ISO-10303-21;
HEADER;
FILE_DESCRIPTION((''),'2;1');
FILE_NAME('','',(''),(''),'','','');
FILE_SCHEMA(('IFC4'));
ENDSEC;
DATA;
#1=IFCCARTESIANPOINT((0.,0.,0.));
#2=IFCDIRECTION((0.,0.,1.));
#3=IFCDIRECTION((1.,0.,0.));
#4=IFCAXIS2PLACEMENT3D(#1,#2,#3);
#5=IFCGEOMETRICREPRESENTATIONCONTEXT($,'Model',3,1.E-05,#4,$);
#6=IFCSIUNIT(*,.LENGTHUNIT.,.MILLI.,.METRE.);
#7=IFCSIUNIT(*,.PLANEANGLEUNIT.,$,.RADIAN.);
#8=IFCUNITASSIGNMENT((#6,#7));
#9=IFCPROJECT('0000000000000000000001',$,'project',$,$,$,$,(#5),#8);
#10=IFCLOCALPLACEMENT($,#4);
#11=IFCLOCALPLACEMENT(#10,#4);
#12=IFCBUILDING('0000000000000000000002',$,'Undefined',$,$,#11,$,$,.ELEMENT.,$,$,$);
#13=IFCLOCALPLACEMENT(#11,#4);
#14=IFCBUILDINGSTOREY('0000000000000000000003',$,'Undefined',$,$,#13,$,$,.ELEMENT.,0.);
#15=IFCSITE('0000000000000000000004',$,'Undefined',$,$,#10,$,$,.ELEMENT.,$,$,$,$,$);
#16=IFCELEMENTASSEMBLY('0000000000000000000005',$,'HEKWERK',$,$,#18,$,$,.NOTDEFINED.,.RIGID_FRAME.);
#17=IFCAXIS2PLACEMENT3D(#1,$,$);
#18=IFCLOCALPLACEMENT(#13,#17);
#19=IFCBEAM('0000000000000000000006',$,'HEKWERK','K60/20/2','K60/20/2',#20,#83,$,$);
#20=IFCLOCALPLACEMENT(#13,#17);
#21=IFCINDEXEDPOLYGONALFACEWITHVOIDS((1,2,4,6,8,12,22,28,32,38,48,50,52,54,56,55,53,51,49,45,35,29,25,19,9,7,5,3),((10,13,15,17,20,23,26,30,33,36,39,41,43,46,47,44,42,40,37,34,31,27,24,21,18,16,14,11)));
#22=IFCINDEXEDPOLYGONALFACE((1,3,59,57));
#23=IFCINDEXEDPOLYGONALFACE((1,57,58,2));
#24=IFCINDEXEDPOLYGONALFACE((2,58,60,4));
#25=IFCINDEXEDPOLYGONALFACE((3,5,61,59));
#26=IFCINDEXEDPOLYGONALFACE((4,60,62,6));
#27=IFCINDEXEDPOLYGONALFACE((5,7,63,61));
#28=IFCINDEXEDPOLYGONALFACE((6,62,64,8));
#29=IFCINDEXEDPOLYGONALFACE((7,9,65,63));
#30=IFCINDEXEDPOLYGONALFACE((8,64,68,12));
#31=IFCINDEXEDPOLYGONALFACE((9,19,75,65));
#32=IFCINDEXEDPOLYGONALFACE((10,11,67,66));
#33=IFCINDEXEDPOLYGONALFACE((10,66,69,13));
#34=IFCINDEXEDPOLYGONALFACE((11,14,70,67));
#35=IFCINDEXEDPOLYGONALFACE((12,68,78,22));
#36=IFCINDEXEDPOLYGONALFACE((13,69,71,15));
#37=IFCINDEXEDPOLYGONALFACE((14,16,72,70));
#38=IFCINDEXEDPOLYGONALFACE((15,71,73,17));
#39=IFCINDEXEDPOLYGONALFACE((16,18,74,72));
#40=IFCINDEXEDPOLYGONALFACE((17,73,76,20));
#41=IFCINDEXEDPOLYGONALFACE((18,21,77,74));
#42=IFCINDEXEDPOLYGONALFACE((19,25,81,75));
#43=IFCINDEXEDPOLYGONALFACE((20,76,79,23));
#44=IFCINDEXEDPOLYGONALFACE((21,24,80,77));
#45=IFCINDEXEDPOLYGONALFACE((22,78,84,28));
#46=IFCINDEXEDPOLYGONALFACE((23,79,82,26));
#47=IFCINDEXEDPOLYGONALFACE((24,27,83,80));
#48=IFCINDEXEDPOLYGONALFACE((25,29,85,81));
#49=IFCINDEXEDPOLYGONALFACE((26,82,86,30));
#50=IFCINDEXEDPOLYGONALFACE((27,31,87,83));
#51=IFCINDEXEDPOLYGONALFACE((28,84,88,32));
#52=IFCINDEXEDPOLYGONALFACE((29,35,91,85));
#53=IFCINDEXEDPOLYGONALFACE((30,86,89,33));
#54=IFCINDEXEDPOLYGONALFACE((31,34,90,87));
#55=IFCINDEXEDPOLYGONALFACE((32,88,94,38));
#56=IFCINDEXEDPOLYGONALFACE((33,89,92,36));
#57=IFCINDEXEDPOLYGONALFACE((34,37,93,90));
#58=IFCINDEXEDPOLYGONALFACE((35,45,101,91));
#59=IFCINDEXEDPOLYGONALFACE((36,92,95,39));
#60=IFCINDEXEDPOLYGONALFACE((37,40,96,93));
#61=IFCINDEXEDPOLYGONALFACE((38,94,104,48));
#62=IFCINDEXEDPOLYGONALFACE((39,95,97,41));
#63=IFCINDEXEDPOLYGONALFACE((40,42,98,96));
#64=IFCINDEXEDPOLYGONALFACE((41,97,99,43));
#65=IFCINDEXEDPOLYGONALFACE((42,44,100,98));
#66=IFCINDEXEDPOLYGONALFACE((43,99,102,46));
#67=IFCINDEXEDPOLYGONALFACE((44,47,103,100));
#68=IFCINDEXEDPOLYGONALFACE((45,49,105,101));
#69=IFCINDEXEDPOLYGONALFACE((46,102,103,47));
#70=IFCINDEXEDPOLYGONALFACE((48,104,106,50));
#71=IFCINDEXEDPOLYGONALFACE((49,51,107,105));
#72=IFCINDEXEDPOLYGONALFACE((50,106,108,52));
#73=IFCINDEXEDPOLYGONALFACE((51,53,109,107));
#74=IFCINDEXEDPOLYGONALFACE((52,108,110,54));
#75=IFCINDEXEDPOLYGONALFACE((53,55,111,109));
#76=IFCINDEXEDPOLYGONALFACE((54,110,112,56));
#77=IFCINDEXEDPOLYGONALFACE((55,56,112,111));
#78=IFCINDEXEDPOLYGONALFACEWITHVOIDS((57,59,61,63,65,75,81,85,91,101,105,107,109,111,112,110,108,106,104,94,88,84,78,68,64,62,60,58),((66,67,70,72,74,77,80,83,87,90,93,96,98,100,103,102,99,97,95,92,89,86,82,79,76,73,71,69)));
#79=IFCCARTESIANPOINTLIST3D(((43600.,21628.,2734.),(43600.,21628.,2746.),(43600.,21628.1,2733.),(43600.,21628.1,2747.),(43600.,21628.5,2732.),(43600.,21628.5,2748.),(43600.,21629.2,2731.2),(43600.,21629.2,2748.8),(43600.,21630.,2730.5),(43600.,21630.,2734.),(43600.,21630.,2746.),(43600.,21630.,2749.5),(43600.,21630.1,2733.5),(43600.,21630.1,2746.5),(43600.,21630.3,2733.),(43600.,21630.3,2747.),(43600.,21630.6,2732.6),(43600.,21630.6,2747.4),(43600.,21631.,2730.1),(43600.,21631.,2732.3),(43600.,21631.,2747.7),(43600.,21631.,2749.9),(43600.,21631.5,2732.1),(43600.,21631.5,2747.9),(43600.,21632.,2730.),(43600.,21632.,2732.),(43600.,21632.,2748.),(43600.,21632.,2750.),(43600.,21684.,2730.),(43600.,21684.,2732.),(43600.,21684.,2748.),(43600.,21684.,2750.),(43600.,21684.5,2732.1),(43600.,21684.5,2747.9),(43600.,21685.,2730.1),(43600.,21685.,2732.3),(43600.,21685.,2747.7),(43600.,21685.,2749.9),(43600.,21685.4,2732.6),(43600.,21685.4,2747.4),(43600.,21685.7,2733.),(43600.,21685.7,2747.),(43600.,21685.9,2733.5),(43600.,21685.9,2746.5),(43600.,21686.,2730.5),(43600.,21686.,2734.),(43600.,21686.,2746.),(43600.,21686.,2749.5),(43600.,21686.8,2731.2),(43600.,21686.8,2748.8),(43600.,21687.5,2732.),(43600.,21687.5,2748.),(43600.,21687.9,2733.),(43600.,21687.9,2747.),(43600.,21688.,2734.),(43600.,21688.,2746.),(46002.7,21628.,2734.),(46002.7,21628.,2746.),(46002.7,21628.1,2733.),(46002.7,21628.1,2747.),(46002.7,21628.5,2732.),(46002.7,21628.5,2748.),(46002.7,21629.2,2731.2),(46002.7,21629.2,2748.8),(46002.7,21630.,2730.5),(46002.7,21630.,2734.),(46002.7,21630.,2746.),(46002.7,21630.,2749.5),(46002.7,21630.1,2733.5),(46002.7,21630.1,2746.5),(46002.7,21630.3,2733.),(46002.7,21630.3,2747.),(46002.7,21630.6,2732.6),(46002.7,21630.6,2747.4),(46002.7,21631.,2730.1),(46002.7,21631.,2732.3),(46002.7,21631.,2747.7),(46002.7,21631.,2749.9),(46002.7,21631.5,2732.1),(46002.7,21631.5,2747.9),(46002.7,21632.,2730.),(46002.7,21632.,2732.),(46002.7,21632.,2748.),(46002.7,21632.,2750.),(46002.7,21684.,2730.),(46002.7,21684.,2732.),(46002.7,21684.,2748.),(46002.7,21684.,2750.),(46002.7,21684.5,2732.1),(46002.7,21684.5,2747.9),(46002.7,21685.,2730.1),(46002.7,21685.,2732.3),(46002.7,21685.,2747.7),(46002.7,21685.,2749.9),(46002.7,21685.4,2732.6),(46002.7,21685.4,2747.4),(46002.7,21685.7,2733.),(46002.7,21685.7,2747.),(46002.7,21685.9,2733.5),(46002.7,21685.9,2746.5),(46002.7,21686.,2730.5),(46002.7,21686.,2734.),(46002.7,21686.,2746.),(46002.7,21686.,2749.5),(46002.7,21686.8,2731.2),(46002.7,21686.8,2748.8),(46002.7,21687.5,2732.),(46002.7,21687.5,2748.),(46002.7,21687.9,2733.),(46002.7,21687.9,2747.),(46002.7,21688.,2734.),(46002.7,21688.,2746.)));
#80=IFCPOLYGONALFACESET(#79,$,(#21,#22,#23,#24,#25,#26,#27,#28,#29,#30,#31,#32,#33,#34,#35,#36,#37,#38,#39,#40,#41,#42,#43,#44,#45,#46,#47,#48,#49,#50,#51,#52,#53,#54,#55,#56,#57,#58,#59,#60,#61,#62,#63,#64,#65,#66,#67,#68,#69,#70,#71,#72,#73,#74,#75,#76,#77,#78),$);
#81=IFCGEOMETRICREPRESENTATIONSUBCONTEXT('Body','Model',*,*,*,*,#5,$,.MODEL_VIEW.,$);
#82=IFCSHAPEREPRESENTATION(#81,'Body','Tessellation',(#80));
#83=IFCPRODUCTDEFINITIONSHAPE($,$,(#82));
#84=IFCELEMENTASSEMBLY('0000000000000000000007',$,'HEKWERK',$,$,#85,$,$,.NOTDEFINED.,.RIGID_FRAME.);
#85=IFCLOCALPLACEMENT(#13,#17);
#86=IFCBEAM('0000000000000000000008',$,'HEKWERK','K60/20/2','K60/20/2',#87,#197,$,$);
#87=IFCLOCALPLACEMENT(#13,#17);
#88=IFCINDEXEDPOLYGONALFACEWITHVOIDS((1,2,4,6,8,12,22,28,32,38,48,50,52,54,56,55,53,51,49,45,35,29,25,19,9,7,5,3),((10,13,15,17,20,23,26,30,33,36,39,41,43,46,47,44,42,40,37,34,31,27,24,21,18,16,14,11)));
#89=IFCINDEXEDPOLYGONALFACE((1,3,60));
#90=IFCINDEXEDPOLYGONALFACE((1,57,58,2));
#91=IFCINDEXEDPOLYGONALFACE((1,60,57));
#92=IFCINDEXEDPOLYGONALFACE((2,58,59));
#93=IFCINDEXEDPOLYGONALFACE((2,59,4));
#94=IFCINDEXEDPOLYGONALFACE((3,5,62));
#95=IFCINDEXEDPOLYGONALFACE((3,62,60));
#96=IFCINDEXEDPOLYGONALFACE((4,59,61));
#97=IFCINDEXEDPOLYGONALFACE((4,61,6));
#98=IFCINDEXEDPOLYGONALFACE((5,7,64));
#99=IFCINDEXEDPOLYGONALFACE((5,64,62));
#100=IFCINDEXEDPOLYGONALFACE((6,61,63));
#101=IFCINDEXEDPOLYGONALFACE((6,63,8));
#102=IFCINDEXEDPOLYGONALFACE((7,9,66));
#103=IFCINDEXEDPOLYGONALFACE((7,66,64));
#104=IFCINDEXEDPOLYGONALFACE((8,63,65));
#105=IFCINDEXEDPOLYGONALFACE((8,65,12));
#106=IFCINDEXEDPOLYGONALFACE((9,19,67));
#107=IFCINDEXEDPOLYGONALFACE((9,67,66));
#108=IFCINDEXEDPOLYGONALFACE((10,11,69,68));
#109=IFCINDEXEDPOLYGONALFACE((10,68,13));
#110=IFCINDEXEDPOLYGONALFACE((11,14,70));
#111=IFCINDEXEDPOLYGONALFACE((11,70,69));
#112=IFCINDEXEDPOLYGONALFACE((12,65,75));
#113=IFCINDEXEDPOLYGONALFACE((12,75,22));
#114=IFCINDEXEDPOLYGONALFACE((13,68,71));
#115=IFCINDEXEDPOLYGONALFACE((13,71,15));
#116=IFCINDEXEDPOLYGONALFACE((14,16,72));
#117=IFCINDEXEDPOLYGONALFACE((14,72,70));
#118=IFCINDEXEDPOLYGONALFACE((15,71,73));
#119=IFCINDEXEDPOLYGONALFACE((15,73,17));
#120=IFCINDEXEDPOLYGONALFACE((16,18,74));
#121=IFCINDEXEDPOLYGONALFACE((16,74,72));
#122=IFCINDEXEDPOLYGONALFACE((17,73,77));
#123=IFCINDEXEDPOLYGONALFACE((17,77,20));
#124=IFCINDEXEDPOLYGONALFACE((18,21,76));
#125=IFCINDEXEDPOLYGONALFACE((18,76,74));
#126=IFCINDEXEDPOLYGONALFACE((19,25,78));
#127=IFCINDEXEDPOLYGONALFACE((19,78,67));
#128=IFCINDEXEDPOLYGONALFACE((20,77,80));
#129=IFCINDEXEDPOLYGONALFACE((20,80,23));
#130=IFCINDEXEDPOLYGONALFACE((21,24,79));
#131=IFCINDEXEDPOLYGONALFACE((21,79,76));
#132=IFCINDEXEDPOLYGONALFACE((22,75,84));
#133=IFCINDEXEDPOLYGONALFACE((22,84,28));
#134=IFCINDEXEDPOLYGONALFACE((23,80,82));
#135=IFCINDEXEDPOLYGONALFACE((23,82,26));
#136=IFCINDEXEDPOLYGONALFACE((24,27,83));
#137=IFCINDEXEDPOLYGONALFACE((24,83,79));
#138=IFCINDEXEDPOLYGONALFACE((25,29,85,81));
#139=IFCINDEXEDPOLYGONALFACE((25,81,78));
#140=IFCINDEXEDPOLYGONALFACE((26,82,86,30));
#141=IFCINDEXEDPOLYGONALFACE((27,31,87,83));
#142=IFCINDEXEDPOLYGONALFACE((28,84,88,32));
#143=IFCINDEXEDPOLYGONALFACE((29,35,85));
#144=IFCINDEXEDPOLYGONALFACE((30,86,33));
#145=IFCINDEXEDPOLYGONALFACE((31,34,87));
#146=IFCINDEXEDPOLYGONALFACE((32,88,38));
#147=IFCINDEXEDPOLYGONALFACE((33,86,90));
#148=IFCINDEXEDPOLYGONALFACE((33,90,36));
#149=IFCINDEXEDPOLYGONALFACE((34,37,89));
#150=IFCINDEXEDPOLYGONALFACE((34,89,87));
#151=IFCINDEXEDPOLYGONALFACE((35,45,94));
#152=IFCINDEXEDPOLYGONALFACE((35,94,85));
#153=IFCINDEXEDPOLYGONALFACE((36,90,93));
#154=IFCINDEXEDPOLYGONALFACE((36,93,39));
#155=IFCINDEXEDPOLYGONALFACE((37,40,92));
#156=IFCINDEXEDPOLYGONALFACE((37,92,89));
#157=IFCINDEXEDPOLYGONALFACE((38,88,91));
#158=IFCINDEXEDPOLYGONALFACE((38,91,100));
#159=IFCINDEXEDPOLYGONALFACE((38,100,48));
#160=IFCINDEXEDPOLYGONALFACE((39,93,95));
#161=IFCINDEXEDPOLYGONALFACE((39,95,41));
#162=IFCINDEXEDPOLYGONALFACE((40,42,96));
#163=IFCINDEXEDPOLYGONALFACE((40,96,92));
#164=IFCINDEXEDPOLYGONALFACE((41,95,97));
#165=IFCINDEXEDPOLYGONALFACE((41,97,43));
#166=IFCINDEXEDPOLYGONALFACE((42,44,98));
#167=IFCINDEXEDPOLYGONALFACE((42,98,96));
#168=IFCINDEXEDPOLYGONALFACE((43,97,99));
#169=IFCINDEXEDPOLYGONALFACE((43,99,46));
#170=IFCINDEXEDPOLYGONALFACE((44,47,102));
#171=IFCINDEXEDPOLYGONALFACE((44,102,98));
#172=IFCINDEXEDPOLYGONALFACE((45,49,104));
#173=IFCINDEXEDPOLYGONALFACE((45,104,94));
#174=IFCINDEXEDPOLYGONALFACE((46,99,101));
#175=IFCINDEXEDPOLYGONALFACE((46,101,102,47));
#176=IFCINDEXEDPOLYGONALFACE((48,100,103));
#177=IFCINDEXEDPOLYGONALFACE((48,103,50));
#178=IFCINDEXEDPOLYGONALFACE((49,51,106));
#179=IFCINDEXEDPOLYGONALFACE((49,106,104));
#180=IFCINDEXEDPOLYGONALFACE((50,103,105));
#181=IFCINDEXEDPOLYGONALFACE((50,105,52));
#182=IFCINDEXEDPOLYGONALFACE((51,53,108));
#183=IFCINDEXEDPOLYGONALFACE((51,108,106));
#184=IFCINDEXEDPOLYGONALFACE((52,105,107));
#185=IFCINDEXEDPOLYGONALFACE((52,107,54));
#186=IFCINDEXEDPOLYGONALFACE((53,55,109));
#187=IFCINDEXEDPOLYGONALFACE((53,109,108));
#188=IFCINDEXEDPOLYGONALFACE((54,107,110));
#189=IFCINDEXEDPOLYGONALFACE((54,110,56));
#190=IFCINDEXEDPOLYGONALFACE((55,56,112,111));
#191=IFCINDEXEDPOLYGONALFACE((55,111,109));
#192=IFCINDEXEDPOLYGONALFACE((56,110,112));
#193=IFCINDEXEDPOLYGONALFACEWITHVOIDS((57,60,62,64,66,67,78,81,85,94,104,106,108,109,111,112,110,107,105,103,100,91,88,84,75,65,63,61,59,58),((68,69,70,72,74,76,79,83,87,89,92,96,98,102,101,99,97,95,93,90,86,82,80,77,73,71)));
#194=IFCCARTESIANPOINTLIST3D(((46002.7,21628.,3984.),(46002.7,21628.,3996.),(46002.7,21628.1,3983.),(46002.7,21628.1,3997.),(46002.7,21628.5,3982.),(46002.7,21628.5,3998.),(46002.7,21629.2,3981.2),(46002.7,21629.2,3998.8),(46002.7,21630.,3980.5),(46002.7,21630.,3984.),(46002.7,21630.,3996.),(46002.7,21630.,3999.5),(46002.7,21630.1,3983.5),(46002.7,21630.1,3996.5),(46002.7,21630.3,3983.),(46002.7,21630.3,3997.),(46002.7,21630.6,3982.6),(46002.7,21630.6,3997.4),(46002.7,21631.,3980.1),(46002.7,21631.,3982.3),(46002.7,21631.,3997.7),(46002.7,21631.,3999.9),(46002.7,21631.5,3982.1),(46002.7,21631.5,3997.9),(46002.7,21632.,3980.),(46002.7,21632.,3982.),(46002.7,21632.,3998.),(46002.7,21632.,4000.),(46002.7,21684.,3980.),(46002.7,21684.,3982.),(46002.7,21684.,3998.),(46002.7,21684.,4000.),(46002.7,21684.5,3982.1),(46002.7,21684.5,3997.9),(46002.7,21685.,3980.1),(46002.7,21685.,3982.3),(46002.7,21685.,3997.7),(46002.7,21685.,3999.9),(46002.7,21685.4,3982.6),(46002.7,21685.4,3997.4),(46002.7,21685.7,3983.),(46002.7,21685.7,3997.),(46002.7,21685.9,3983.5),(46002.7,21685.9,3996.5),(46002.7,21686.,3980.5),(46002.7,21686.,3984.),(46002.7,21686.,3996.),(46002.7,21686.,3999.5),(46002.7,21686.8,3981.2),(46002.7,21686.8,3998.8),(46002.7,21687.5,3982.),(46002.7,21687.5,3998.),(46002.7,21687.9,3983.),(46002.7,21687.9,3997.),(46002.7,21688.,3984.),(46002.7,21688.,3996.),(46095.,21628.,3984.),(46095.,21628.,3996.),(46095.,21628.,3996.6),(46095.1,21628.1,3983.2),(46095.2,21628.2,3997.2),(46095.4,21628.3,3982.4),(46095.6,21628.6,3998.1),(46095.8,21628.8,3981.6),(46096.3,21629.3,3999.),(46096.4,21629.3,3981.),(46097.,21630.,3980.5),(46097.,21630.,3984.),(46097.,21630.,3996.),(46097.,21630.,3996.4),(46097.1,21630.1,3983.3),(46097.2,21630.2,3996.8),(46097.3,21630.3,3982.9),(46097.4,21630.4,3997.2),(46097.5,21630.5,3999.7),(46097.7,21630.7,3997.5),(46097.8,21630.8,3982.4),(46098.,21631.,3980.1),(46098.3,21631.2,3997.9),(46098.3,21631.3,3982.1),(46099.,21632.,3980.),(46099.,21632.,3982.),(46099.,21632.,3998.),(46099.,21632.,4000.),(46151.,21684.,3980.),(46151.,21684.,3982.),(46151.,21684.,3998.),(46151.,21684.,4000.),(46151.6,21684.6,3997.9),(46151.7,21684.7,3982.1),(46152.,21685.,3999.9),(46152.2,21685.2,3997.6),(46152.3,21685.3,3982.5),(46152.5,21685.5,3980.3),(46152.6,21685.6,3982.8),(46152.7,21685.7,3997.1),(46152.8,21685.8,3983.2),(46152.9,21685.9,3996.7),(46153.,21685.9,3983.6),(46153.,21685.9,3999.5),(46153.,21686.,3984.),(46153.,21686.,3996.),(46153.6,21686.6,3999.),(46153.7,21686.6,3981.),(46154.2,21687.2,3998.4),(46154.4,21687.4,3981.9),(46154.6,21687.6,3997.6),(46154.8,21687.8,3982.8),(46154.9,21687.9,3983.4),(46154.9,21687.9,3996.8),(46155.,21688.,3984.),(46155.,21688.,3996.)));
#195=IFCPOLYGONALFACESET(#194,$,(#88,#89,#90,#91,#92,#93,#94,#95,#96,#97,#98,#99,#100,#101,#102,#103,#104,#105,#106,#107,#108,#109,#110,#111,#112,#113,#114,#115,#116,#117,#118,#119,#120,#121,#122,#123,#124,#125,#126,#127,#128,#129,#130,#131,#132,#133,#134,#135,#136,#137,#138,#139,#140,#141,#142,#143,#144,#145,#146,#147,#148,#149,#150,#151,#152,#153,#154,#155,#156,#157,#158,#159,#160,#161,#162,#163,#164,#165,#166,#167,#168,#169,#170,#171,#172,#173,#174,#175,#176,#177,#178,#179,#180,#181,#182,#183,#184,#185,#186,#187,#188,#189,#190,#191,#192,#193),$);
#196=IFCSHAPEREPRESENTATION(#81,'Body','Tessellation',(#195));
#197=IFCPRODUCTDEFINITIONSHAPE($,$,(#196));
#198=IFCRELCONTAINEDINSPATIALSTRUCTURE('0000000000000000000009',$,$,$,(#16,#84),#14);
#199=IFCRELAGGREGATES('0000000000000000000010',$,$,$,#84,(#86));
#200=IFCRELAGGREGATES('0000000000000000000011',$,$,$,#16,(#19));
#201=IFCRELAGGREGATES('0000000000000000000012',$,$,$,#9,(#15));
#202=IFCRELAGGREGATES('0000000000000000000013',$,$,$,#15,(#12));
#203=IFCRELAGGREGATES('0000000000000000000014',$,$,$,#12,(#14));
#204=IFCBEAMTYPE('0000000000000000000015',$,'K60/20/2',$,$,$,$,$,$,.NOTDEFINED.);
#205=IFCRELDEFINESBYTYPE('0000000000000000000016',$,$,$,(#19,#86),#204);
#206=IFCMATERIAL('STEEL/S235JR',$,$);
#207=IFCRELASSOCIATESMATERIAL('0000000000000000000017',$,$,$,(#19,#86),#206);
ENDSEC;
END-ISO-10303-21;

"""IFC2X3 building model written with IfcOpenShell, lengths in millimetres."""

from ifc_helpers import new_model, si_unit, frame, origin_with_axes, origin_2d_with_axis, place, context, subcontext, project, spatial, hollow_rectangle, extrude, clip, halfspace, material, type_object, element, aggregate, save


model = new_model("IFC2X3")

# Units and contexts
model_context = context("Model", 3, precision=1e-05, world=origin_with_axes())
body_context = subcontext(model_context, "Body", "Model", "MODEL_VIEW")
ifc_project = project(units=[si_unit("LENGTHUNIT", "METRE", prefix="MILLI"), si_unit("PLANEANGLEUNIT", "RADIAN")], contexts=[model_context])

# Site, building, storey
site_placement = place(None, origin_with_axes())
site = spatial("IfcSite", under=ifc_project, at=site_placement, Name="Undefined", CompositionType="ELEMENT")
building_placement = place(site_placement, origin_with_axes())
building = spatial("IfcBuilding", under=site, at=building_placement, Name="Undefined", CompositionType="ELEMENT")
storey_placement = place(building_placement, origin_with_axes())
storey = spatial("IfcBuildingStorey", under=building, at=storey_placement, Name="Undefined", CompositionType="ELEMENT", Elevation=0.0)

# Element assembly, beam
assembly_1_placement = place(storey_placement, origin_with_axes())
assembly_1 = element("IfcElementAssembly", 1, at=assembly_1_placement, inside=storey, Name="HEKWERK", AssemblyPlace="NOTDEFINED", PredefinedType="RIGID_FRAME")
ifc_material_1 = material(Name="STEEL/S235JR")
beam_type_1 = type_object("IfcBeamType", Name="K60/20/2", PredefinedType="NOTDEFINED")
beam_1_placement = place(assembly_1_placement, frame((46002.7, 21658.0, 2740.0), z_axis=(0.0, -1.0, 0.0), x_axis=(-1.0, 0.0, 0.0)))
beam_1 = element("IfcBeam", 2, at=beam_1_placement, type_object=beam_type_1, material=ifc_material_1, Name="HEKWERK", Description="K60/20/2", ObjectType="K60/20/2", context=body_context, shape_type="SweptSolid", body=[
    extrude(hollow_rectangle(XDim=20.0, YDim=60.0, WallThickness=2.0, InnerFilletRadius=2.0, OuterFilletRadius=4.0, at=origin_2d_with_axis()), frame((2402.7, 0.0, 0.0), z_axis=(-1.0, 0.0, 0.0), x_axis=(0.0, -1.0, 0.0)), (0.0, 0.0, 1.0), 2402.7),
])

# Element assembly, beam
assembly_2_placement = place(storey_placement, origin_with_axes())
assembly_2 = element("IfcElementAssembly", 3, at=assembly_2_placement, inside=storey, Name="HEKWERK", AssemblyPlace="NOTDEFINED", PredefinedType="RIGID_FRAME")
beam_2_placement = place(assembly_2_placement, frame((46098.4, 21658.0, 3990.0), z_axis=(0.0, -1.0, 0.0), x_axis=(-1.0, 0.0, 0.0)))
beam_2 = element("IfcBeam", 4, at=beam_2_placement, type_object=beam_type_1, material=ifc_material_1, Name="HEKWERK", Description="K60/20/2", ObjectType="K60/20/2", context=body_context, shape_type="Clipping", body=[
    clip(extrude(hollow_rectangle(XDim=20.0, YDim=60.0, WallThickness=2.0, InnerFilletRadius=2.0, OuterFilletRadius=4.0, at=origin_2d_with_axis()), frame((95.8, 0.0, 0.0), z_axis=(-1.0, 0.0, 0.0), x_axis=(0.0, -1.0, 0.0)), (0.0, 0.0, 1.0), 152.6), halfspace(frame((3.4, 0.0, 30.0), z_axis=(-0.707107, 0.0, 0.707107), x_axis=(0.0, -1.0, 0.0)), False)),
])

aggregate(assembly_2, [beam_2])
aggregate(assembly_1, [beam_1])

save(model, "model.ifc")
